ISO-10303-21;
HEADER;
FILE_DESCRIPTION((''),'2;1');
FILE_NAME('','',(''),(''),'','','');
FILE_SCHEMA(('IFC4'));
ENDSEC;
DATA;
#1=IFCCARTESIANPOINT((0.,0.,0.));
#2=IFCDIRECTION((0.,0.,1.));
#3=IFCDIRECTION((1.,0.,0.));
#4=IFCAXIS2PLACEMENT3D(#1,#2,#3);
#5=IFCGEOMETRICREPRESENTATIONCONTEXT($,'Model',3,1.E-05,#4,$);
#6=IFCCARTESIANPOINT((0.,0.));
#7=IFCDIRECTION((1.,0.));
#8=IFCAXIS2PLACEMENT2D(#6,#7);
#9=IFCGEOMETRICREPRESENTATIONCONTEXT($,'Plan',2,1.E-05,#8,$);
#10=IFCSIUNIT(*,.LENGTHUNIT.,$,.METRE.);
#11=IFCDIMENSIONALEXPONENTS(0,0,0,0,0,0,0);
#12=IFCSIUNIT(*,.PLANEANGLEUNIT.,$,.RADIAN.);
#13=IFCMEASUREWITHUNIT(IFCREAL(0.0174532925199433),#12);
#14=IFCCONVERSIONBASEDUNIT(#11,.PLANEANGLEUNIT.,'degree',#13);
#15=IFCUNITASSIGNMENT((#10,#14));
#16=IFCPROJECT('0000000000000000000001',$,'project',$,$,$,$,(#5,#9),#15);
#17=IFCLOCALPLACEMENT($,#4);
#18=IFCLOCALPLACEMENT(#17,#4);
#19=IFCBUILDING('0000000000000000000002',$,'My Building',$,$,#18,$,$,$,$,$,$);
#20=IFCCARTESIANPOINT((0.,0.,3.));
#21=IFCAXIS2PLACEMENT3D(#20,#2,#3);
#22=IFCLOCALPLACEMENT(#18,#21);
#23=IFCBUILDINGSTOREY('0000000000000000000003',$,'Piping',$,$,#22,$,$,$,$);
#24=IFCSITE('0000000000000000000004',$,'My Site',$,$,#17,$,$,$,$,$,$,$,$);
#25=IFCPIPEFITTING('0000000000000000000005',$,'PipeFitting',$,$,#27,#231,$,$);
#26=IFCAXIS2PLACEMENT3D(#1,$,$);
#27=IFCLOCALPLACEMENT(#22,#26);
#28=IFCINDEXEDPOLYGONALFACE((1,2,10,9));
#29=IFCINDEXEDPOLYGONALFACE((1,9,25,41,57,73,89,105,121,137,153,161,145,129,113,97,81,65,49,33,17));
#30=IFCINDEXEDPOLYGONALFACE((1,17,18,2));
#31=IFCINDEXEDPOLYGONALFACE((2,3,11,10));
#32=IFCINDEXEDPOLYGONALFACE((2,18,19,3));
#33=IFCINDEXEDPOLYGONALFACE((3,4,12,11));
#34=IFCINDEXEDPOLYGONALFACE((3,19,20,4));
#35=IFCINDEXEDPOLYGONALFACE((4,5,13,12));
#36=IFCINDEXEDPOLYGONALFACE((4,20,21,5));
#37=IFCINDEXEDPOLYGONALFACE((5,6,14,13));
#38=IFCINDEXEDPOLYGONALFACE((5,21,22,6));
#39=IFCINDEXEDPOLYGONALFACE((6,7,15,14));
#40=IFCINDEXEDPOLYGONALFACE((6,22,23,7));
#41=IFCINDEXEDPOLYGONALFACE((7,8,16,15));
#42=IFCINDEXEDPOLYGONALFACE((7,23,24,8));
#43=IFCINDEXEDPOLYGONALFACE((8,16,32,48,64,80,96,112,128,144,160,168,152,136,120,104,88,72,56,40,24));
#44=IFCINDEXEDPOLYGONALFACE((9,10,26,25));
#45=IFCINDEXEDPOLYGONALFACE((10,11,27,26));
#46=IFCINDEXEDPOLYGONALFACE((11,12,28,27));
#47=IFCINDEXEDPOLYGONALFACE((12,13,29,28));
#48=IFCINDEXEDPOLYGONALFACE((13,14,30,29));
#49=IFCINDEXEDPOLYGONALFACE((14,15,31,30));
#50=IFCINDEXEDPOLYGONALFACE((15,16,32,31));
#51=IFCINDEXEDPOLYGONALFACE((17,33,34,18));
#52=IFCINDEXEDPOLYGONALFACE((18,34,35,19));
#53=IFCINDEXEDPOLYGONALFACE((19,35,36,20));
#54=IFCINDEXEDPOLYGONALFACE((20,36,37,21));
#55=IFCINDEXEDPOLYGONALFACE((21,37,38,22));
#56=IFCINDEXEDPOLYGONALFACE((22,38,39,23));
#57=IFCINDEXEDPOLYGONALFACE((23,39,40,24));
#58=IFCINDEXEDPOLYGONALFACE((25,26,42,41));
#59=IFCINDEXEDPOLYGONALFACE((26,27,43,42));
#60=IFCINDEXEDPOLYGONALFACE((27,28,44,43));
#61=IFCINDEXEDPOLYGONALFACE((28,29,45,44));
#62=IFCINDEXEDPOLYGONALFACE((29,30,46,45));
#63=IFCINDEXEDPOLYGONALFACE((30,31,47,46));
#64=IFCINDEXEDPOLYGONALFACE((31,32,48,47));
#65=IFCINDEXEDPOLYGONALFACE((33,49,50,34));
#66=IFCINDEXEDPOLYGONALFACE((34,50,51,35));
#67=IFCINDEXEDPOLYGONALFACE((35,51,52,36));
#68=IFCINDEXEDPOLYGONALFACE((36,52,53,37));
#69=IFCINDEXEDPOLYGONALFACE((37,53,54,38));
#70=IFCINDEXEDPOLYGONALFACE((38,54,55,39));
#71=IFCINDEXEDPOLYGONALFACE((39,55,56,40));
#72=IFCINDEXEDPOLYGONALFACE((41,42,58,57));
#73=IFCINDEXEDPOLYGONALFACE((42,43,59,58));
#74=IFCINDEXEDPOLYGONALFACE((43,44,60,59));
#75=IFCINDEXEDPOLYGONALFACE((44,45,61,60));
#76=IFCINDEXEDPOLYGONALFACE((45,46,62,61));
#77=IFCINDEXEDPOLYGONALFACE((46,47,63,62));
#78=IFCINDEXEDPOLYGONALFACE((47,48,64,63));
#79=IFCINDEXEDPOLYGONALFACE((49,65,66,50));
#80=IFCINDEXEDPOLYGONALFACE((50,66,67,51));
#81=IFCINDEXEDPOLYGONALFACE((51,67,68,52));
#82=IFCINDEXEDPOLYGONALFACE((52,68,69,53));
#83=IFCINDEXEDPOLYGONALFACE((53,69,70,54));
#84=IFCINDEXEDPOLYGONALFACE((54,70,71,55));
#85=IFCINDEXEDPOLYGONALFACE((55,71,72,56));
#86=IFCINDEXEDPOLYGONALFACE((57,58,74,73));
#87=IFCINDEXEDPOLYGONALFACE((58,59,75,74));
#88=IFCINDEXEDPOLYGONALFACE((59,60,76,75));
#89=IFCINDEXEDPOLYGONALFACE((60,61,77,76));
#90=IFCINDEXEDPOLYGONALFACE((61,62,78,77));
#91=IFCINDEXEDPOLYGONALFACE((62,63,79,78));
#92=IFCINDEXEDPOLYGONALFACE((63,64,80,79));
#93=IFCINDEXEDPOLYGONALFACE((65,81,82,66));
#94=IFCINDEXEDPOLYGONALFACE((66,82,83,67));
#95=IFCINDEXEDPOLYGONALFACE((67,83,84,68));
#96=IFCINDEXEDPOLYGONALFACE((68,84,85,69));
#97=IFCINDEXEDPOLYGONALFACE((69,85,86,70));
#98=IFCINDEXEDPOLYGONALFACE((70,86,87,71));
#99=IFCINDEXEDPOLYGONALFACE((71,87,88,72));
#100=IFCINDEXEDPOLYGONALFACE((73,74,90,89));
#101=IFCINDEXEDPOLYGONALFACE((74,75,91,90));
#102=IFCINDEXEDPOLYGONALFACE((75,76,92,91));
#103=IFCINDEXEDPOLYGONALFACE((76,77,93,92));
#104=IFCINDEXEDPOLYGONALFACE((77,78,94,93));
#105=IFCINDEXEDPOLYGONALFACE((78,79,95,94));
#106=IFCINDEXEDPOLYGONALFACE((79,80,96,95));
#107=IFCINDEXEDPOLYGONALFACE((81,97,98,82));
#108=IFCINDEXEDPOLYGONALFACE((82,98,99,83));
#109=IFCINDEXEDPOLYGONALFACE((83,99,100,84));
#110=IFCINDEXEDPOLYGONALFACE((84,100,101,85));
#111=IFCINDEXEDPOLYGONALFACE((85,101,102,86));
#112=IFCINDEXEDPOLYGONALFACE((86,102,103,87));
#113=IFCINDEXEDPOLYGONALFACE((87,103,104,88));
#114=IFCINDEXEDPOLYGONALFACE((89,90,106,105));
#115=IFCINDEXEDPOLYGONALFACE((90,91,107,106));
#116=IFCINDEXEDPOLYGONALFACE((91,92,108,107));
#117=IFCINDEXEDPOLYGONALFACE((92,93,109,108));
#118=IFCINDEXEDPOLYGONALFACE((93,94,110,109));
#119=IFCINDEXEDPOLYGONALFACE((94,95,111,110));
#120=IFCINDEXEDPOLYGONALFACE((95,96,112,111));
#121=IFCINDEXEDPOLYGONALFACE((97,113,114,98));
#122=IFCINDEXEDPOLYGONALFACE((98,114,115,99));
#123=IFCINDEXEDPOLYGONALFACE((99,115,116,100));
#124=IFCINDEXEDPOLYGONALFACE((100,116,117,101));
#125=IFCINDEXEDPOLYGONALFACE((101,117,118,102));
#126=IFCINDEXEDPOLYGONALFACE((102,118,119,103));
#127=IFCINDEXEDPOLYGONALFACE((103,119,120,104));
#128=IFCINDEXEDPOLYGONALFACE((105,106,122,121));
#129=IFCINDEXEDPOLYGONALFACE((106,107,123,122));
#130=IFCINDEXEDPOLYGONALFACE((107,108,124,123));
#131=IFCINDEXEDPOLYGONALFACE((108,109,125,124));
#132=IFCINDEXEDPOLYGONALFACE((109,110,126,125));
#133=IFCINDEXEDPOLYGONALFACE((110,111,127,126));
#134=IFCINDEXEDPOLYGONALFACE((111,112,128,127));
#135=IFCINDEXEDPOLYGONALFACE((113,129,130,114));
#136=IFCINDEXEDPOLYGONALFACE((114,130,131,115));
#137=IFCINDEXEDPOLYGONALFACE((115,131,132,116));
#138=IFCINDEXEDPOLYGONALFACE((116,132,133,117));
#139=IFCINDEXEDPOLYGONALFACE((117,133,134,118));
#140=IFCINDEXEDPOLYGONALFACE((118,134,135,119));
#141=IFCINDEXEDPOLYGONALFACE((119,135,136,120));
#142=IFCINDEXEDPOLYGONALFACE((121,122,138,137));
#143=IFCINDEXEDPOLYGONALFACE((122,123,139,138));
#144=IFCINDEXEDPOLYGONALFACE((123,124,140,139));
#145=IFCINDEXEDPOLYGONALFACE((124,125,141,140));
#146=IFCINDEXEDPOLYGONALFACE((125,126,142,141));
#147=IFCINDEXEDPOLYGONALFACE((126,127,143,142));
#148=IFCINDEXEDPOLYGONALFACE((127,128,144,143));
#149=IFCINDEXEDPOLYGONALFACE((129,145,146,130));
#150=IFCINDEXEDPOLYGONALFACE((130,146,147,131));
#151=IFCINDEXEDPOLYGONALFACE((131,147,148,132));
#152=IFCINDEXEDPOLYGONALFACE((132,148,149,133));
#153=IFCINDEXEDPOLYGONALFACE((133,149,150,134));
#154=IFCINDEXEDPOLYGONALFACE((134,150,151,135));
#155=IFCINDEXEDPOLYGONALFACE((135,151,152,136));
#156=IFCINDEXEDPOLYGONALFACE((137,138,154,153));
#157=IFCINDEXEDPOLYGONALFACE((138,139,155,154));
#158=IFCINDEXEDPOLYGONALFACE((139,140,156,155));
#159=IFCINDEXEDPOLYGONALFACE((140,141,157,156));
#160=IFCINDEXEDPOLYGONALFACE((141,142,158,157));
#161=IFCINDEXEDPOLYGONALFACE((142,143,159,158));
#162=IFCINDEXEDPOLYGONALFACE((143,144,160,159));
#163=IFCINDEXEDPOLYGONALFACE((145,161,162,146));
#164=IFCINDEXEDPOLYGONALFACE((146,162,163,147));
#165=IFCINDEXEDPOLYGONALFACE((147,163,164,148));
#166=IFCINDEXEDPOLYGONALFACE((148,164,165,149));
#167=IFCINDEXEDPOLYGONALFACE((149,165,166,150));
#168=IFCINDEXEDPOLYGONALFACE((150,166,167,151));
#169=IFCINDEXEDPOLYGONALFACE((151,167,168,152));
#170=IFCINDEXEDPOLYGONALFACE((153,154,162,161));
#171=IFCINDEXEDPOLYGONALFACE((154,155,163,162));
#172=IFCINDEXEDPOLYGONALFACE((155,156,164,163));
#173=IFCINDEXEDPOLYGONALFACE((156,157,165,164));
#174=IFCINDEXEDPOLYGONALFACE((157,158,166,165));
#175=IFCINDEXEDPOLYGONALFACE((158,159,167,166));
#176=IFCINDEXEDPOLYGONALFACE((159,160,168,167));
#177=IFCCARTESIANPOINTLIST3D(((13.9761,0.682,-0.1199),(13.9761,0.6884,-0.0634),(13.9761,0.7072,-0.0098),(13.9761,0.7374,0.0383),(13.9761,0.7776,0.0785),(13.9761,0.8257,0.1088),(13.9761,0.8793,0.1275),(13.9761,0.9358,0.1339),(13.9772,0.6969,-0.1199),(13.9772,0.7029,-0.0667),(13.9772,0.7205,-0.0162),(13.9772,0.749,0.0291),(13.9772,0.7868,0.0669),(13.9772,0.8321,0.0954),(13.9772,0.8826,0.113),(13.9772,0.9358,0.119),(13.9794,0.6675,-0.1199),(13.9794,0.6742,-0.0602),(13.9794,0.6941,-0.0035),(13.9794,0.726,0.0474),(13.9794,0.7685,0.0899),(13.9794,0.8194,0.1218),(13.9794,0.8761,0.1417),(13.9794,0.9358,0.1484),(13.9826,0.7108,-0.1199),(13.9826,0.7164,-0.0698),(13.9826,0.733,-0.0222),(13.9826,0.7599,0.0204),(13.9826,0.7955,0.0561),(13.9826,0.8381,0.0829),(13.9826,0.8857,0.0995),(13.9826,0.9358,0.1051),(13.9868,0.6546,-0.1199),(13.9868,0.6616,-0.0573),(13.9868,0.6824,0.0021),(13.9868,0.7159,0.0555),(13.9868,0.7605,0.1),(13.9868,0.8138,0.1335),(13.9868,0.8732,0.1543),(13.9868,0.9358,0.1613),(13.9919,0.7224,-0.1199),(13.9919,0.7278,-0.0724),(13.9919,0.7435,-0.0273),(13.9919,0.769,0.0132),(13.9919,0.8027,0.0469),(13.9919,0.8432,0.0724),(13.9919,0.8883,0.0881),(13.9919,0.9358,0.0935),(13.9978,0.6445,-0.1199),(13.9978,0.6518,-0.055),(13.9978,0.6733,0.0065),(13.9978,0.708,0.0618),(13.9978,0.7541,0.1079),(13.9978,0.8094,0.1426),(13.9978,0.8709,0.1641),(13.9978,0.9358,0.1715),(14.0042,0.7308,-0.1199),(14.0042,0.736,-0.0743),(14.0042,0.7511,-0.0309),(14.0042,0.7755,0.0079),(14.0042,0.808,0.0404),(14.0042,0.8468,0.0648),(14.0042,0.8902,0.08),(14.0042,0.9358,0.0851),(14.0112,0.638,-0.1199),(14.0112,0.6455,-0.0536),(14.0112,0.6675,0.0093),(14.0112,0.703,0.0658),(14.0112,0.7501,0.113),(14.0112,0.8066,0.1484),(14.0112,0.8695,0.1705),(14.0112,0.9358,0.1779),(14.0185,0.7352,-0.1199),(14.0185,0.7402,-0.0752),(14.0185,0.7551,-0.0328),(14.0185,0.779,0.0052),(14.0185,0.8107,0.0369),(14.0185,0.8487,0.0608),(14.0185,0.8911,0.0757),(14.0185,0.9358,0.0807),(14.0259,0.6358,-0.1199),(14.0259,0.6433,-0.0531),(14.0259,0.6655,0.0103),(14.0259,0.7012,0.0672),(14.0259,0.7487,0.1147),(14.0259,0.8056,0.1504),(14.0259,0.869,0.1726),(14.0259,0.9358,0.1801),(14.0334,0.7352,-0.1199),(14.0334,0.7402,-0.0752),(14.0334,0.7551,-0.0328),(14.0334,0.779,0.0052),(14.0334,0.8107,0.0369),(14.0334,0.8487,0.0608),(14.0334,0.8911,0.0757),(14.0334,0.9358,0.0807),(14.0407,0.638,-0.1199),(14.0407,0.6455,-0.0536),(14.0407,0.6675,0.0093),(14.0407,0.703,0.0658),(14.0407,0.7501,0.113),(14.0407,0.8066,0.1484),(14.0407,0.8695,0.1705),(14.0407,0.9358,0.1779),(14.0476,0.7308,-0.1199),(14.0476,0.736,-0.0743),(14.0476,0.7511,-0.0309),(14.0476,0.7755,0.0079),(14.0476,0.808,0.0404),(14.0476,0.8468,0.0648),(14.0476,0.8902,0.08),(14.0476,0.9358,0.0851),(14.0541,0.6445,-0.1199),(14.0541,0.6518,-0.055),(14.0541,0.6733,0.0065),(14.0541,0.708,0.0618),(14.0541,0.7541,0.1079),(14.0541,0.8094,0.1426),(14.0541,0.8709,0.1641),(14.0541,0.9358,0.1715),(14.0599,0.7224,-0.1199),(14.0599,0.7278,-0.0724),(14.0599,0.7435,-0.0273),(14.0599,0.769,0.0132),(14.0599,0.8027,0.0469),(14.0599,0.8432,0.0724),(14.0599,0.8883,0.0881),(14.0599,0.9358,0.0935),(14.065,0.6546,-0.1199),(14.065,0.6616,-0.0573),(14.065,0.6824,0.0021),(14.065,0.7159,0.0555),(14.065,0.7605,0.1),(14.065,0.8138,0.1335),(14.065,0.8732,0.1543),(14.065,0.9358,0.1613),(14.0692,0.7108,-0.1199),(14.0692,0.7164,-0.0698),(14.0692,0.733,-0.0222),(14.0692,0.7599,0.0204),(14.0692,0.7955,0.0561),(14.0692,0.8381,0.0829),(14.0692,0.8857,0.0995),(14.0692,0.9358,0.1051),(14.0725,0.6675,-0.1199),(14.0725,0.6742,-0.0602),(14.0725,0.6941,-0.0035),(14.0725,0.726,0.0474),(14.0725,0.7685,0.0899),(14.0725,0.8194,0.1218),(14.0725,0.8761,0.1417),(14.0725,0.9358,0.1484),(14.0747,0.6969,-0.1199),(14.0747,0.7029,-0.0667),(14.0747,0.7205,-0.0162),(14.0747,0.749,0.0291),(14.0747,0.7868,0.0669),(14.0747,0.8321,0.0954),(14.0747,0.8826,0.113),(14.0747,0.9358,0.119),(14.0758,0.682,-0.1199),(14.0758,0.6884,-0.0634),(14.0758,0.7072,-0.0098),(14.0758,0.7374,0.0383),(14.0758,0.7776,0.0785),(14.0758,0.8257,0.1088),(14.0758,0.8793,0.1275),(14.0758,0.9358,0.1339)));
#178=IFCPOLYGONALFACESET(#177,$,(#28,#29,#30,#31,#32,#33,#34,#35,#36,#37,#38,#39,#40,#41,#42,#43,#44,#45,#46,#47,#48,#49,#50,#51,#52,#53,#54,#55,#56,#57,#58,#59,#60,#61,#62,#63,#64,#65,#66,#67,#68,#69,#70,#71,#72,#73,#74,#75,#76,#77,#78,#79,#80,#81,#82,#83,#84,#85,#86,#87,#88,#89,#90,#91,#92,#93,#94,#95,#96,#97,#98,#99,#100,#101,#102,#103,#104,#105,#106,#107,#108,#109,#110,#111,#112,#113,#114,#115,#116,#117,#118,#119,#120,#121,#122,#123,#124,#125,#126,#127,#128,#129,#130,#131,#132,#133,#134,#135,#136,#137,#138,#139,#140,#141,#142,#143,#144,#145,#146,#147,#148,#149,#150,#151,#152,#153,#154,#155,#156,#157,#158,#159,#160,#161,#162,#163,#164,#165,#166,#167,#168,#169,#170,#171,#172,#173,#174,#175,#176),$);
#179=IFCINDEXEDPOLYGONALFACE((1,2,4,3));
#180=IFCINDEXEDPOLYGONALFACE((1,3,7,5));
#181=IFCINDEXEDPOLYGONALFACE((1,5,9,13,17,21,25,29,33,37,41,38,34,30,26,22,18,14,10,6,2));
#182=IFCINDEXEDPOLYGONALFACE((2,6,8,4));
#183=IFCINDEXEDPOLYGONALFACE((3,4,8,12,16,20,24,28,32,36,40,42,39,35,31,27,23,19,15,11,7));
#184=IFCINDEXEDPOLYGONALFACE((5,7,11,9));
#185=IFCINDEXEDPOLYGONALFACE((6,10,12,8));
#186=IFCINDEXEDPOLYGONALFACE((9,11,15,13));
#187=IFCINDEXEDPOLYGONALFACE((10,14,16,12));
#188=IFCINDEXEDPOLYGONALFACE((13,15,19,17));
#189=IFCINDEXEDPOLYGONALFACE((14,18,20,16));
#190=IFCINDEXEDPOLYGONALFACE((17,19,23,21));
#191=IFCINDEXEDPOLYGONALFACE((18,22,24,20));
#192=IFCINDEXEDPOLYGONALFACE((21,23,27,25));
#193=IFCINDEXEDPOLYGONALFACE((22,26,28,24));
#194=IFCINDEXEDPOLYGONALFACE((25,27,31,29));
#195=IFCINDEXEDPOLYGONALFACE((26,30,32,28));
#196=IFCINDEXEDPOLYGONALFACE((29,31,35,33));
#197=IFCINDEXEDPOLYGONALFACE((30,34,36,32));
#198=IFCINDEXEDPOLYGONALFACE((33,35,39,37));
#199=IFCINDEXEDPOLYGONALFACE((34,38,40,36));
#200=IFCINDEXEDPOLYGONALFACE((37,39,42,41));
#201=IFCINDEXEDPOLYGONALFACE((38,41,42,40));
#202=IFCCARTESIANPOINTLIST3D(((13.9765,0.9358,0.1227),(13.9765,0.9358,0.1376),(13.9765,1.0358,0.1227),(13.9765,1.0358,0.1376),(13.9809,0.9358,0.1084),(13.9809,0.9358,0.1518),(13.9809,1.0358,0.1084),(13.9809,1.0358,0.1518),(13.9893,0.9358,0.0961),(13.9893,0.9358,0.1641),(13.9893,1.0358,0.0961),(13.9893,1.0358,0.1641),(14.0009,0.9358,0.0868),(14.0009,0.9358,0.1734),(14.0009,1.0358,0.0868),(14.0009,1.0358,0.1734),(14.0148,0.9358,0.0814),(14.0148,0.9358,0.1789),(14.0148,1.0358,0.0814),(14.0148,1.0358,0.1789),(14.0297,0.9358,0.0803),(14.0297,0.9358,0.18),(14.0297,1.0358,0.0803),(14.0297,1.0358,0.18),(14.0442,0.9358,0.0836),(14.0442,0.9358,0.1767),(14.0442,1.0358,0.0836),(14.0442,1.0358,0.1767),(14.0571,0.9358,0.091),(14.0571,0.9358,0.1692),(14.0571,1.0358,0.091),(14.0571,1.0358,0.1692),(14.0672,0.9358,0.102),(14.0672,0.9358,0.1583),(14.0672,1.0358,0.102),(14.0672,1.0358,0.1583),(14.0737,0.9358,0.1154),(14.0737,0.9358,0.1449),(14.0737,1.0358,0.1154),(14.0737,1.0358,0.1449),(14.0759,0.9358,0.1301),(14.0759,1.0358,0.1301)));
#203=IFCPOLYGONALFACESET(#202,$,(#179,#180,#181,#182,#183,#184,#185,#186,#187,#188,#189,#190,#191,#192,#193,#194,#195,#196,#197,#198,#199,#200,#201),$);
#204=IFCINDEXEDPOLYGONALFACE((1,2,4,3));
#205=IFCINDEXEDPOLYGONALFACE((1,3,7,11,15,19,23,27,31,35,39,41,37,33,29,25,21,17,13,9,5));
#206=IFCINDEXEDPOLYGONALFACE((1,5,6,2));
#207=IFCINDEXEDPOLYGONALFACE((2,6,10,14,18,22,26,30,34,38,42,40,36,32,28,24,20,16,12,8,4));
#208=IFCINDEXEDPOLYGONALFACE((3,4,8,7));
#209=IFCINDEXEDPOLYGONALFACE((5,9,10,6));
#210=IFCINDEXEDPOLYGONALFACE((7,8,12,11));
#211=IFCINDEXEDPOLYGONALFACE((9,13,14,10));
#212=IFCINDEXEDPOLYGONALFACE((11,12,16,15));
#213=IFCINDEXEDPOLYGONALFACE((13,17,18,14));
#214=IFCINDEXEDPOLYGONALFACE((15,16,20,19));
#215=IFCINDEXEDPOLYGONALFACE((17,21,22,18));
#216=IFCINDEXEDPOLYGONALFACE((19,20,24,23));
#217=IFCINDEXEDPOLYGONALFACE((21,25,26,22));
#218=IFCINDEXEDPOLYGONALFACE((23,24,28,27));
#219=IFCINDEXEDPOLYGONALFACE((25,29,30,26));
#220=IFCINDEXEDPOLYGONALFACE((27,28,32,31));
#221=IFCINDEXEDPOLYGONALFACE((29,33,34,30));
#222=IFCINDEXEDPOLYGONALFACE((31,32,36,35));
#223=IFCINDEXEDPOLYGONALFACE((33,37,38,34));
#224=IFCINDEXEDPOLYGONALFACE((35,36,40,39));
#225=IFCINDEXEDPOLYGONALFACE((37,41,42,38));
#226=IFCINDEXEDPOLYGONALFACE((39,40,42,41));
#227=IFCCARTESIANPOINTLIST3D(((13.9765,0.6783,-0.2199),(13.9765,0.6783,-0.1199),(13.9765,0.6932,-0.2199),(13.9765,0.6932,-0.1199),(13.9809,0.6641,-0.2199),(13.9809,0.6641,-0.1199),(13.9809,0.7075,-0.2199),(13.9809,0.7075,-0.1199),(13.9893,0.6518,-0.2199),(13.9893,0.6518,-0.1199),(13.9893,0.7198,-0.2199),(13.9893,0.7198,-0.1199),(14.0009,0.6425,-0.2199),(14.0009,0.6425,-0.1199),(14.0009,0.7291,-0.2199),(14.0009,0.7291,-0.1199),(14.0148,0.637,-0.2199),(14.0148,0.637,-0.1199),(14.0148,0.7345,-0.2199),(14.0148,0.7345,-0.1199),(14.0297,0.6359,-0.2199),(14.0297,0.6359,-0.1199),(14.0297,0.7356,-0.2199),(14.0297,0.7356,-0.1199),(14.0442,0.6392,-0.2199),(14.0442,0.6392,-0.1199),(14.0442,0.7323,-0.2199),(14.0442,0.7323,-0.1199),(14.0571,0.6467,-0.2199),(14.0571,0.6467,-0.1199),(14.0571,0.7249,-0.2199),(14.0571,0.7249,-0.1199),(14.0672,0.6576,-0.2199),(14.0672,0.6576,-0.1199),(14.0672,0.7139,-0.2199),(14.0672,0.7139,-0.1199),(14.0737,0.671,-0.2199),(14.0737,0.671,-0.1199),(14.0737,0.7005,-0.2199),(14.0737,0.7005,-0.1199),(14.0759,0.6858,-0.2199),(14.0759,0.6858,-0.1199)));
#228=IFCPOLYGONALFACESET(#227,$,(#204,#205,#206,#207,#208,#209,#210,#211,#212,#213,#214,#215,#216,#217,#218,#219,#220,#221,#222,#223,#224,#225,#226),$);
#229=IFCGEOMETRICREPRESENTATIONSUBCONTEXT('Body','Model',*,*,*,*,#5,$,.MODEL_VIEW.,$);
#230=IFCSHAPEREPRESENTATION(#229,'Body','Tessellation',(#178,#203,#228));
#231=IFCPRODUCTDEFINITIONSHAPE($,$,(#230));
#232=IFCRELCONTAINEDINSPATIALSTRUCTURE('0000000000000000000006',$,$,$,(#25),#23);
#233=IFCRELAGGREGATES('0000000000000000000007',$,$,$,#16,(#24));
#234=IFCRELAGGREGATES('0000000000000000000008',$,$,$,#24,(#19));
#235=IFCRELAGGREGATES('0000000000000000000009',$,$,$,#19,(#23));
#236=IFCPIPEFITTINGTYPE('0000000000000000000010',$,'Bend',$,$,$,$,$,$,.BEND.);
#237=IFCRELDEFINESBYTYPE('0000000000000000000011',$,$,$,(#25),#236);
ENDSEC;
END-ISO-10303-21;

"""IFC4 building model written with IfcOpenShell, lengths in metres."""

from ifc_helpers import new_model, entity, si_unit, converted_unit, frame, origin_with_axes, origin_2d_with_axis, place, context, subcontext, project, spatial, circle, extrude, source, transform, mapped, type_object, type_shapes, element, save


model = new_model("IFC4")

# Units and contexts
model_context = context("Model", 3, precision=1e-05, world=origin_with_axes())
plan_context = context("Plan", 2, precision=1e-05, world=origin_2d_with_axis())
body_context = subcontext(model_context, "Body", "Model", "MODEL_VIEW")
ifc_project = project(units=[si_unit("LENGTHUNIT", "METRE"), converted_unit("PLANEANGLEUNIT", "degree", entity("IfcReal", 0.0174532925199433), si_unit("PLANEANGLEUNIT", "RADIAN"), dimensions=[0, 0, 0, 0, 0, 0, 0])], contexts=[model_context, plan_context])

# Site, building, storey
site_placement = place(None, origin_with_axes())
site = spatial("IfcSite", under=ifc_project, at=site_placement, Name="My Site")
building_placement = place(site_placement, origin_with_axes())
building = spatial("IfcBuilding", under=site, at=building_placement, Name="My Building")
storey_placement = place(building_placement, frame((0.0, 0.0, 3.0), z_axis=(0.0, 0.0, 1.0), x_axis=(1.0, 0.0, 0.0)))
storey = spatial("IfcBuildingStorey", under=building, at=storey_placement, Name="Piping")

# Pipe fitting
pipe_fitting_type_1 = type_object("IfcPipeFittingType", Name="Bend", PredefinedType="BEND")
shared_shape_1 = source(origin_with_axes(), body_context, "Body", "SolidModel", [
    entity("IfcSweptDiskSolid", entity("IfcIndexedPolyCurve", entity("IfcCartesianPointList3D", [[0.0, 0.0, 0.1], [0.0, -0.0732, 0.2768], [0.0, -0.25, 0.35]]), [entity("IfcArcIndex", [1, 2, 3])]), 0.05),
    extrude(circle(Radius=0.05), origin_with_axes(), (0.0, 0.0, 1.0), 0.1),
    extrude(circle(Radius=0.05), frame((0.0, -0.25, 0.35), z_axis=(0.0, -1.0, -0.000015), x_axis=(1.0, 0.0, 0.0)), (0.0, 0.0, 1.0), 0.1),
])
type_shapes(pipe_fitting_type_1, [shared_shape_1])
for number, where, z_axis, x_axis, name in (
    (1, (14.0259, 1.0358, 0.1301), (0.0, -1.0, 0.000015), (1.0, 0.0, 0.0), "PipeFitting"),
):
    element("IfcPipeFitting", number, at=place(storey_placement, frame(where, z_axis=z_axis, x_axis=x_axis)), inside=storey, type_object=pipe_fitting_type_1, Name=name, context=body_context, shape_type="MappedRepresentation", body=[
        mapped(shared_shape_1, transform((0.0, 0.0, 0.0), x_axis=(1.0, 0.0, 0.0), y_axis=(0.0, 1.0, 0.0), z_axis=(0.0, 0.0, 1.0), scale=1.0)),
    ])

save(model, "model.ifc")
